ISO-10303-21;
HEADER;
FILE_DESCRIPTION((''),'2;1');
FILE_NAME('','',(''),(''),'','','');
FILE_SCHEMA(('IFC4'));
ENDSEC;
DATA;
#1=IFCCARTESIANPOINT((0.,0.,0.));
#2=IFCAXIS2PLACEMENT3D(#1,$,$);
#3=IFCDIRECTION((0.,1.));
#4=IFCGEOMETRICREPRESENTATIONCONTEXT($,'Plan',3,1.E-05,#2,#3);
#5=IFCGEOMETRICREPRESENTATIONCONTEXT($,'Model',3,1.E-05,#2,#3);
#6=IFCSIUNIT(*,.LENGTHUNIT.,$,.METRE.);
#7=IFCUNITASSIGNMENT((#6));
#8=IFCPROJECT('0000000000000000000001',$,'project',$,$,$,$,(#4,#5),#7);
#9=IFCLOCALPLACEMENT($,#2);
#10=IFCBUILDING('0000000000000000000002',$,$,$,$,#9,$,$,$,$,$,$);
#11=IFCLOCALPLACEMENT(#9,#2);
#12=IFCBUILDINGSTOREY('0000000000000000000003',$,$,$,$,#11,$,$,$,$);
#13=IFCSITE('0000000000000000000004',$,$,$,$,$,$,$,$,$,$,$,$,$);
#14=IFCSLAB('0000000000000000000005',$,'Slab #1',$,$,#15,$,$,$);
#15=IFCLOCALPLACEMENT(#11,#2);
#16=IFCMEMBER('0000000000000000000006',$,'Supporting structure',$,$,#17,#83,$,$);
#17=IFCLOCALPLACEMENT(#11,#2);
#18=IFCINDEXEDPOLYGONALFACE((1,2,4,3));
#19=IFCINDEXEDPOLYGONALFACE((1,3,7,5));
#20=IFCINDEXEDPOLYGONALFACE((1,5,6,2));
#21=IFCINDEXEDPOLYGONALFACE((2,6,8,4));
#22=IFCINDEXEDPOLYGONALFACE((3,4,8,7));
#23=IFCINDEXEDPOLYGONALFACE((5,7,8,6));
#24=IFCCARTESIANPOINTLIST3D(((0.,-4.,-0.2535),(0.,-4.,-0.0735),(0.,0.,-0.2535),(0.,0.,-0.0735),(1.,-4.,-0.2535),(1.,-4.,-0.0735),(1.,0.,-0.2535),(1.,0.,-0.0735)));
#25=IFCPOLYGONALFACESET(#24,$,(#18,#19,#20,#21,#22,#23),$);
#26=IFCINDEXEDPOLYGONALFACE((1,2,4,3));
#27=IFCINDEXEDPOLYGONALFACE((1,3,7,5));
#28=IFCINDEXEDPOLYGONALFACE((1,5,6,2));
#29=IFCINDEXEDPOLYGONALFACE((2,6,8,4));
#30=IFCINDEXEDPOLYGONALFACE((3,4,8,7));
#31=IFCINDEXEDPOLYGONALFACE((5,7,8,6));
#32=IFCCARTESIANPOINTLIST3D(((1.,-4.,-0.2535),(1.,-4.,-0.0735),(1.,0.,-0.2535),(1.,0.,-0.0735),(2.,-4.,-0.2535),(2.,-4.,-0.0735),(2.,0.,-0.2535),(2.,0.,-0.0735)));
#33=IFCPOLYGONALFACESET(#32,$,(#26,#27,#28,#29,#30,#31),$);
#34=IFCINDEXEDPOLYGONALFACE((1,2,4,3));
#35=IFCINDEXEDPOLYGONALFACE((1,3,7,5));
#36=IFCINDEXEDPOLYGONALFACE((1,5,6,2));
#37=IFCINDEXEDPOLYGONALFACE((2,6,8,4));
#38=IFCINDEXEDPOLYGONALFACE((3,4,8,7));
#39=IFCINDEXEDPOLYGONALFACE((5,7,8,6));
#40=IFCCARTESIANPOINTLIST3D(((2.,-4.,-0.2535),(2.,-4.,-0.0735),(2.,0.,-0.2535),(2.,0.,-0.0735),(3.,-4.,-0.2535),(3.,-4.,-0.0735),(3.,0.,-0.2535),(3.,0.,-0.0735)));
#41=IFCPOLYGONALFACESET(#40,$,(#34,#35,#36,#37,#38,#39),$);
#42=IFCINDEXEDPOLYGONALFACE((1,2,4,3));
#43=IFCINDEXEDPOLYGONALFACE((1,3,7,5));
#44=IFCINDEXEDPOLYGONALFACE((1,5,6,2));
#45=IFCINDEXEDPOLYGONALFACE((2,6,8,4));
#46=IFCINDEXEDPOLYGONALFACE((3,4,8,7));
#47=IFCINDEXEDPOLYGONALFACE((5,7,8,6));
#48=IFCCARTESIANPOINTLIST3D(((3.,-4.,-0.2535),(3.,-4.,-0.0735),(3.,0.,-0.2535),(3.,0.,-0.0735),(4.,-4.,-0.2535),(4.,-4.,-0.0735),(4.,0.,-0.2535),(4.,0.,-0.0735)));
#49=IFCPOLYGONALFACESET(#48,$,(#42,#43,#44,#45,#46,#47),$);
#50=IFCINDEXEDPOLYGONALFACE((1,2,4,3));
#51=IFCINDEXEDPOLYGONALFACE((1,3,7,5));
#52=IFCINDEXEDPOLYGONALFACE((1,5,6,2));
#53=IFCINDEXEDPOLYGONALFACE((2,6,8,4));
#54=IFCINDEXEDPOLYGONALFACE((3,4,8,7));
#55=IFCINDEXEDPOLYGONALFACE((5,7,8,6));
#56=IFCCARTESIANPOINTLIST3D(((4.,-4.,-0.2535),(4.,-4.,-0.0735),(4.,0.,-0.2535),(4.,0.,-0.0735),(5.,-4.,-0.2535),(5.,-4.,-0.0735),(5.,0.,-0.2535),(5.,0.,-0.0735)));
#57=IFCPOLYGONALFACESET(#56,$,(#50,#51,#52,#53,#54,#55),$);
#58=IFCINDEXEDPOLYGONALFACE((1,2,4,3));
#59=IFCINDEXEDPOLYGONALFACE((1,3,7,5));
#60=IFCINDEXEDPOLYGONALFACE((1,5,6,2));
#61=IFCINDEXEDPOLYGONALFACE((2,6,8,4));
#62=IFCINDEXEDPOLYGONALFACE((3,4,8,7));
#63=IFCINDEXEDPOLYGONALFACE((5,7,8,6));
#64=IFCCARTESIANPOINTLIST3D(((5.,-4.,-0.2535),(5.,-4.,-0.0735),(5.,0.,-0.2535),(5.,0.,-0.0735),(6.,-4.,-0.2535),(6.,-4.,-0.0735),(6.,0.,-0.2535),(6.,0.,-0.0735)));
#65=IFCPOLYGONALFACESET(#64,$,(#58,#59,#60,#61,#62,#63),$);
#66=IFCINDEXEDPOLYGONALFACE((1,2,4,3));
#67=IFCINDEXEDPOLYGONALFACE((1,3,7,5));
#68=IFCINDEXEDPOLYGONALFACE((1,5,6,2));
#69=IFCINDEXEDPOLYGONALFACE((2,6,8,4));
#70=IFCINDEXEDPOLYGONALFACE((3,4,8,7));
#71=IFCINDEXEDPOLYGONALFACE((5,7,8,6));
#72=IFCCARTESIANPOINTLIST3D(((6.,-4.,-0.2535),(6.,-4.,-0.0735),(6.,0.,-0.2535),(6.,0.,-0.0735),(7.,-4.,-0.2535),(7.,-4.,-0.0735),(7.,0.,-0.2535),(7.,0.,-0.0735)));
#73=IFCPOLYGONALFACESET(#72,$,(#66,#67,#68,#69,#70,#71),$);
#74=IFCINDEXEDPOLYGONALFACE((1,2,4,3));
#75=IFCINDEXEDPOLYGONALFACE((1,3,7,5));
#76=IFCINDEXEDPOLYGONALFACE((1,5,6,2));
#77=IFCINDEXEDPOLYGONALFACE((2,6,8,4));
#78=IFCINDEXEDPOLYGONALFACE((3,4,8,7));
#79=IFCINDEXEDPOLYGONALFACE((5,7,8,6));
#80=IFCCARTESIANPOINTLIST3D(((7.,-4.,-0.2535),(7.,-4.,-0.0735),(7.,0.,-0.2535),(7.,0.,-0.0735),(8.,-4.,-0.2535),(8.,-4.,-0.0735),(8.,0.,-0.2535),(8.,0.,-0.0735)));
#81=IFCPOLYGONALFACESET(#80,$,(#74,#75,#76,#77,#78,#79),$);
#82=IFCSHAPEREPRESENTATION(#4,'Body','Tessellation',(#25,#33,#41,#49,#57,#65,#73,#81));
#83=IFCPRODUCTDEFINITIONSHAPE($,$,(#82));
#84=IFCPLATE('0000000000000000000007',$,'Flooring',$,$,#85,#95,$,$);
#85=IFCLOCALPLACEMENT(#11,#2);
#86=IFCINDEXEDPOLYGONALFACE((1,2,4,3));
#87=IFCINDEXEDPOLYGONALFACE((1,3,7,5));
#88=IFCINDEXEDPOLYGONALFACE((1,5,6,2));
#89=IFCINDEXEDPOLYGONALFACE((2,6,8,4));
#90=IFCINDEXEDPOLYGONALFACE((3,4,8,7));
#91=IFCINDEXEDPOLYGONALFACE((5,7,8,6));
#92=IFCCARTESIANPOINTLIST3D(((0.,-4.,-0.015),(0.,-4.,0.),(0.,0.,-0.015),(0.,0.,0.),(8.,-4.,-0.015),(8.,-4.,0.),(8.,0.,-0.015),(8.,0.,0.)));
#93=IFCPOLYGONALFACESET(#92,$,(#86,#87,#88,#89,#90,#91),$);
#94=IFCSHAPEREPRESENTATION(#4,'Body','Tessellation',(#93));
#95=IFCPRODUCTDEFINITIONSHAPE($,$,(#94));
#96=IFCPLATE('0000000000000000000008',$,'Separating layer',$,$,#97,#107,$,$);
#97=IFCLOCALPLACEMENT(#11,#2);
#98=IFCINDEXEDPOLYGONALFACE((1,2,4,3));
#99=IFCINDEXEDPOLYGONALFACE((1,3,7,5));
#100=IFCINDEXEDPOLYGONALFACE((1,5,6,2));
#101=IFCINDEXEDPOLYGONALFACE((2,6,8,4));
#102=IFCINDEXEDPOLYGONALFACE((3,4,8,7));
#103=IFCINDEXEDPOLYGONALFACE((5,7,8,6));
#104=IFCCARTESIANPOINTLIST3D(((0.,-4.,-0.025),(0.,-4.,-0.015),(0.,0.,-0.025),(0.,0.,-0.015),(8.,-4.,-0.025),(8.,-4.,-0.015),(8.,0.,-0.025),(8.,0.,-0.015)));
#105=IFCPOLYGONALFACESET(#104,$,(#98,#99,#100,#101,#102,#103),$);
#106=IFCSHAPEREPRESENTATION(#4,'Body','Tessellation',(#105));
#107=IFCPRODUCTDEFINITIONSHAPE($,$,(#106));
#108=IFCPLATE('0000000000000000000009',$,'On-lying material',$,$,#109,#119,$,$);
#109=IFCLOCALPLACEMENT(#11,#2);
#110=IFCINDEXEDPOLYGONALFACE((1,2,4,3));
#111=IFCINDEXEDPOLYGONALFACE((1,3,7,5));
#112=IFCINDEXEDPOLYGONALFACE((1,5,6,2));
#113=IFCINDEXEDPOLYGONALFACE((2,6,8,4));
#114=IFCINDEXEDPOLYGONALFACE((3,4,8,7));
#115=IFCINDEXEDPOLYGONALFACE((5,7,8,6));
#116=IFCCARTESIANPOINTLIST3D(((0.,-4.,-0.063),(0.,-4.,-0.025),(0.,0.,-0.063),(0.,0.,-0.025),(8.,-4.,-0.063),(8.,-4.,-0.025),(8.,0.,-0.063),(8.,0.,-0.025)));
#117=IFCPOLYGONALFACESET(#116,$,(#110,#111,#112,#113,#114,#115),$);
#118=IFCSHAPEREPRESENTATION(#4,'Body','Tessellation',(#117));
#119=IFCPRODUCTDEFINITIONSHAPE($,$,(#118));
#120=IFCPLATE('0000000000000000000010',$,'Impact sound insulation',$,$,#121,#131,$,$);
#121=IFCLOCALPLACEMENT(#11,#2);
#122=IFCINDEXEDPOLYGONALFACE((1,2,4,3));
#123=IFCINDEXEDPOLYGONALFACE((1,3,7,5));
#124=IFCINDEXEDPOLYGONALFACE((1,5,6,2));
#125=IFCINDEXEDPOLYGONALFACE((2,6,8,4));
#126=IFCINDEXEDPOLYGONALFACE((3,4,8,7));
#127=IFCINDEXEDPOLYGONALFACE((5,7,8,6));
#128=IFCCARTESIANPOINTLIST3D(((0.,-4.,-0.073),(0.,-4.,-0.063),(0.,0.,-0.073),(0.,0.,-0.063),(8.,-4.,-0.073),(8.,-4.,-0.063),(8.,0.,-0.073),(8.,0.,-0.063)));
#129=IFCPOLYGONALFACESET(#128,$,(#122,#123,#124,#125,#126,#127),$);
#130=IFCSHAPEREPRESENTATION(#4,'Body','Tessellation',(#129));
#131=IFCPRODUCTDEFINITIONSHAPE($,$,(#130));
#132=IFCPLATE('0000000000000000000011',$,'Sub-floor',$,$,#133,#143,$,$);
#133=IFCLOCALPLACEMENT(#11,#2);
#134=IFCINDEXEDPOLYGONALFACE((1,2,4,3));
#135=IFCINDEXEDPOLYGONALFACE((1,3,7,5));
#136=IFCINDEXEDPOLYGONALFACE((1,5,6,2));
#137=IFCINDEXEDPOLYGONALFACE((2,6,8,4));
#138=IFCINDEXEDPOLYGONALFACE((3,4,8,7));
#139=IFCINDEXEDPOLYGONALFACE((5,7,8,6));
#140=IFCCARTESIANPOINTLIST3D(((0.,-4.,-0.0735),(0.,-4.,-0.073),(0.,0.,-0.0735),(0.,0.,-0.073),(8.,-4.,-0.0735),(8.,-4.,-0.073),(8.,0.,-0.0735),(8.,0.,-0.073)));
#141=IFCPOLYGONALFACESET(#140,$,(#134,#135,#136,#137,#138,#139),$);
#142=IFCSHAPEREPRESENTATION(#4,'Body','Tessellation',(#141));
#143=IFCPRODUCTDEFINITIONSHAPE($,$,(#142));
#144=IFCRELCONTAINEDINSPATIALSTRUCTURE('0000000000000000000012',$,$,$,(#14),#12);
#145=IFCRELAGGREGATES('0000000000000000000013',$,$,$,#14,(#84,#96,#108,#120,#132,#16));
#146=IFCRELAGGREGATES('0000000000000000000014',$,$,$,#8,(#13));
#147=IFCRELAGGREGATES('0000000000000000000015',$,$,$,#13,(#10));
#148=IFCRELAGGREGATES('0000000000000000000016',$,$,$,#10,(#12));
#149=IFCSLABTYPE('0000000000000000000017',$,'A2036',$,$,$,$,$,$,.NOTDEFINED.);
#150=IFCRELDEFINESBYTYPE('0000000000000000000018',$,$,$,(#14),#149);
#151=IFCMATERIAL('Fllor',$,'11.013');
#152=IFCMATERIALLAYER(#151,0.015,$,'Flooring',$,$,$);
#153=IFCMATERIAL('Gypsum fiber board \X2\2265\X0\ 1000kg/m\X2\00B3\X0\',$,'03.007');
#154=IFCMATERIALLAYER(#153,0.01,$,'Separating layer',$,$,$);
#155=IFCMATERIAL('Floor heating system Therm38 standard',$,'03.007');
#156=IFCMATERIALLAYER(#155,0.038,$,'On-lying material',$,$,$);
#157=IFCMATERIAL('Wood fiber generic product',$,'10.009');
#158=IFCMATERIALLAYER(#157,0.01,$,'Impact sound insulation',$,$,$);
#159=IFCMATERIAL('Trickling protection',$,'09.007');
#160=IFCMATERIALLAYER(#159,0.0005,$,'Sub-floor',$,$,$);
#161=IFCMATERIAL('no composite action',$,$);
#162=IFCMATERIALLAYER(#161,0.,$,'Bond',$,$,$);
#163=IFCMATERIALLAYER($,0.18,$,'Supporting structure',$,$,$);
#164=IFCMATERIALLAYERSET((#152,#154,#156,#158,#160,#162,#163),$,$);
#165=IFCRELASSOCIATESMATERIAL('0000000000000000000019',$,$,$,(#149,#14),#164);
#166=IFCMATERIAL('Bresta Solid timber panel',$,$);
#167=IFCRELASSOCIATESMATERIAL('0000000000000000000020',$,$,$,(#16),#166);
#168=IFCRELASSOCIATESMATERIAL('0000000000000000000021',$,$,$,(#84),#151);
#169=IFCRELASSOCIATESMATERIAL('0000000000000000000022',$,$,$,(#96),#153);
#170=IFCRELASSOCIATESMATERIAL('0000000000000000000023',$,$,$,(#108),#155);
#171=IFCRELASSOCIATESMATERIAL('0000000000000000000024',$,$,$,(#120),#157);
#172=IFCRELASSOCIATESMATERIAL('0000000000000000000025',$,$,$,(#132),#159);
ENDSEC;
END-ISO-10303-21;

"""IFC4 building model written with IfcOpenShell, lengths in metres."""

from ifc_helpers import new_model, si_unit, direction, frame, frame_2d, origin, origin_with_axes, place, context, project, spatial, rectangle, extrude, material, layer, layer_set, type_object, element, aggregate, save


model = new_model("IFC4")

# Units and contexts
plan_context = context("Plan", 3, precision=1e-05, world=origin(), true_north=direction((0.0, 1.0)))
model_context = context("Model", 3, precision=1e-05, world=origin(), true_north=direction((0.0, 1.0)))
ifc_project = project(units=[si_unit("LENGTHUNIT", "METRE")], contexts=[plan_context, model_context])

# Site, building, storey
site = spatial("IfcSite", under=ifc_project)
building_placement = place(None, origin())
building = spatial("IfcBuilding", under=site, at=building_placement)
storey_placement = place(building_placement, origin())
storey = spatial("IfcBuildingStorey", under=building, at=storey_placement)

# Slab, member, plates
ifc_material_1 = material(Name="Fllor", Category="11.013")
ifc_layer_1 = layer(ifc_material_1, 0.015, Name="Flooring")
ifc_material_2 = material(Name="Gypsum fiber board ≥ 1000kg/m³", Category="03.007")
ifc_layer_2 = layer(ifc_material_2, 0.01, Name="Separating layer")
ifc_material_3 = material(Name="Floor heating system Therm38 standard", Category="03.007")
ifc_layer_3 = layer(ifc_material_3, 0.038, Name="On-lying material")
ifc_material_4 = material(Name="Wood fiber generic product", Category="10.009")
ifc_layer_4 = layer(ifc_material_4, 0.01, Name="Impact sound insulation")
ifc_material_5 = material(Name="Trickling protection", Category="09.007")
ifc_layer_5 = layer(ifc_material_5, 0.0005, Name="Sub-floor")
ifc_material_6 = material(Name="no composite action")
ifc_layer_6 = layer(ifc_material_6, 0.0, Name="Bond")
ifc_layer_7 = layer(None, 0.18, Name="Supporting structure")
ifc_layer_set = layer_set([ifc_layer_1, ifc_layer_2, ifc_layer_3, ifc_layer_4, ifc_layer_5, ifc_layer_6, ifc_layer_7])
slab_type = type_object("IfcSlabType", Name="A2036", PredefinedType="NOTDEFINED", material=ifc_layer_set)
slab_placement = place(None, frame((0.0, 0.0, 0.0), z_axis=(0.0, 0.0, -1.0), x_axis=(1.0, 0.0, 0.0)))
slab = element("IfcSlab", 1, at=slab_placement, inside=storey, type_object=slab_type, material=ifc_layer_set, Name="Slab #1")
ifc_material_7 = material(Name="Bresta Solid timber panel")
member_placement = place(slab_placement, origin())
member = element("IfcMember", 2, at=member_placement, material=ifc_material_7, Name="Supporting structure", context=plan_context, shape_type="SweptSolid", body=[
    extrude(rectangle(XDim=1.0, YDim=0.18, at=frame_2d((0.5, 0.09), x_axis=(1.0, 0.0))), frame((0.0, 4.0, 0.0735), z_axis=(0.0, -1.0, 0.0), x_axis=(1.0, 0.0, 0.0)), (0.0, 0.0, 1.0), 4.0),
    extrude(rectangle(XDim=1.0, YDim=0.18, at=frame_2d((0.5, 0.09), x_axis=(1.0, 0.0))), frame((1.0, 4.0, 0.0735), z_axis=(0.0, -1.0, 0.0), x_axis=(1.0, 0.0, 0.0)), (0.0, 0.0, 1.0), 4.0),
    extrude(rectangle(XDim=1.0, YDim=0.18, at=frame_2d((0.5, 0.09), x_axis=(1.0, 0.0))), frame((2.0, 4.0, 0.0735), z_axis=(0.0, -1.0, 0.0), x_axis=(1.0, 0.0, 0.0)), (0.0, 0.0, 1.0), 4.0),
    extrude(rectangle(XDim=1.0, YDim=0.18, at=frame_2d((0.5, 0.09), x_axis=(1.0, 0.0))), frame((3.0, 4.0, 0.0735), z_axis=(0.0, -1.0, 0.0), x_axis=(1.0, 0.0, 0.0)), (0.0, 0.0, 1.0), 4.0),
    extrude(rectangle(XDim=1.0, YDim=0.18, at=frame_2d((0.5, 0.09), x_axis=(1.0, 0.0))), frame((4.0, 4.0, 0.0735), z_axis=(0.0, -1.0, 0.0), x_axis=(1.0, 0.0, 0.0)), (0.0, 0.0, 1.0), 4.0),
    extrude(rectangle(XDim=1.0, YDim=0.18, at=frame_2d((0.5, 0.09), x_axis=(1.0, 0.0))), frame((5.0, 4.0, 0.0735), z_axis=(0.0, -1.0, 0.0), x_axis=(1.0, 0.0, 0.0)), (0.0, 0.0, 1.0), 4.0),
    extrude(rectangle(XDim=1.0, YDim=0.18, at=frame_2d((0.5, 0.09), x_axis=(1.0, 0.0))), frame((6.0, 4.0, 0.0735), z_axis=(0.0, -1.0, 0.0), x_axis=(1.0, 0.0, 0.0)), (0.0, 0.0, 1.0), 4.0),
    extrude(rectangle(XDim=1.0, YDim=0.18, at=frame_2d((0.5, 0.09), x_axis=(1.0, 0.0))), frame((7.0, 4.0, 0.0735), z_axis=(0.0, -1.0, 0.0), x_axis=(1.0, 0.0, 0.0)), (0.0, 0.0, 1.0), 4.0),
])
plate_1_placement = place(slab_placement, origin())
plate_1 = element("IfcPlate", 3, at=plate_1_placement, material=ifc_material_1, Name="Flooring", context=plan_context, shape_type="SweptSolid", body=[
    extrude(rectangle(XDim=8.0, YDim=4.0, at=frame_2d((4.0, 2.0), x_axis=(1.0, 0.0))), origin_with_axes(), (0.0, 0.0, 1.0), 0.015),
])
plate_2_placement = place(slab_placement, origin())
plate_2 = element("IfcPlate", 4, at=plate_2_placement, material=ifc_material_2, Name="Separating layer", context=plan_context, shape_type="SweptSolid", body=[
    extrude(rectangle(XDim=8.0, YDim=4.0, at=frame_2d((4.0, 2.0), x_axis=(1.0, 0.0))), frame((0.0, 0.0, 0.015), z_axis=(0.0, 0.0, 1.0), x_axis=(1.0, 0.0, 0.0)), (0.0, 0.0, 1.0), 0.01),
])
plate_3_placement = place(slab_placement, origin())
plate_3 = element("IfcPlate", 5, at=plate_3_placement, material=ifc_material_3, Name="On-lying material", context=plan_context, shape_type="SweptSolid", body=[
    extrude(rectangle(XDim=8.0, YDim=4.0, at=frame_2d((4.0, 2.0), x_axis=(1.0, 0.0))), frame((0.0, 0.0, 0.025), z_axis=(0.0, 0.0, 1.0), x_axis=(1.0, 0.0, 0.0)), (0.0, 0.0, 1.0), 0.038),
])
plate_4_placement = place(slab_placement, origin())
plate_4 = element("IfcPlate", 6, at=plate_4_placement, material=ifc_material_4, Name="Impact sound insulation", context=plan_context, shape_type="SweptSolid", body=[
    extrude(rectangle(XDim=8.0, YDim=4.0, at=frame_2d((4.0, 2.0), x_axis=(1.0, 0.0))), frame((0.0, 0.0, 0.063), z_axis=(0.0, 0.0, 1.0), x_axis=(1.0, 0.0, 0.0)), (0.0, 0.0, 1.0), 0.01),
])
plate_5_placement = place(slab_placement, origin())
plate_5 = element("IfcPlate", 7, at=plate_5_placement, material=ifc_material_5, Name="Sub-floor", context=plan_context, shape_type="SweptSolid", body=[
    extrude(rectangle(XDim=8.0, YDim=4.0, at=frame_2d((4.0, 2.0), x_axis=(1.0, 0.0))), frame((0.0, 0.0, 0.073), z_axis=(0.0, 0.0, 1.0), x_axis=(1.0, 0.0, 0.0)), (0.0, 0.0, 1.0), 0.0005),
])
aggregate(slab, [plate_1, plate_2, plate_3, plate_4, plate_5, member])

save(model, "model.ifc")
